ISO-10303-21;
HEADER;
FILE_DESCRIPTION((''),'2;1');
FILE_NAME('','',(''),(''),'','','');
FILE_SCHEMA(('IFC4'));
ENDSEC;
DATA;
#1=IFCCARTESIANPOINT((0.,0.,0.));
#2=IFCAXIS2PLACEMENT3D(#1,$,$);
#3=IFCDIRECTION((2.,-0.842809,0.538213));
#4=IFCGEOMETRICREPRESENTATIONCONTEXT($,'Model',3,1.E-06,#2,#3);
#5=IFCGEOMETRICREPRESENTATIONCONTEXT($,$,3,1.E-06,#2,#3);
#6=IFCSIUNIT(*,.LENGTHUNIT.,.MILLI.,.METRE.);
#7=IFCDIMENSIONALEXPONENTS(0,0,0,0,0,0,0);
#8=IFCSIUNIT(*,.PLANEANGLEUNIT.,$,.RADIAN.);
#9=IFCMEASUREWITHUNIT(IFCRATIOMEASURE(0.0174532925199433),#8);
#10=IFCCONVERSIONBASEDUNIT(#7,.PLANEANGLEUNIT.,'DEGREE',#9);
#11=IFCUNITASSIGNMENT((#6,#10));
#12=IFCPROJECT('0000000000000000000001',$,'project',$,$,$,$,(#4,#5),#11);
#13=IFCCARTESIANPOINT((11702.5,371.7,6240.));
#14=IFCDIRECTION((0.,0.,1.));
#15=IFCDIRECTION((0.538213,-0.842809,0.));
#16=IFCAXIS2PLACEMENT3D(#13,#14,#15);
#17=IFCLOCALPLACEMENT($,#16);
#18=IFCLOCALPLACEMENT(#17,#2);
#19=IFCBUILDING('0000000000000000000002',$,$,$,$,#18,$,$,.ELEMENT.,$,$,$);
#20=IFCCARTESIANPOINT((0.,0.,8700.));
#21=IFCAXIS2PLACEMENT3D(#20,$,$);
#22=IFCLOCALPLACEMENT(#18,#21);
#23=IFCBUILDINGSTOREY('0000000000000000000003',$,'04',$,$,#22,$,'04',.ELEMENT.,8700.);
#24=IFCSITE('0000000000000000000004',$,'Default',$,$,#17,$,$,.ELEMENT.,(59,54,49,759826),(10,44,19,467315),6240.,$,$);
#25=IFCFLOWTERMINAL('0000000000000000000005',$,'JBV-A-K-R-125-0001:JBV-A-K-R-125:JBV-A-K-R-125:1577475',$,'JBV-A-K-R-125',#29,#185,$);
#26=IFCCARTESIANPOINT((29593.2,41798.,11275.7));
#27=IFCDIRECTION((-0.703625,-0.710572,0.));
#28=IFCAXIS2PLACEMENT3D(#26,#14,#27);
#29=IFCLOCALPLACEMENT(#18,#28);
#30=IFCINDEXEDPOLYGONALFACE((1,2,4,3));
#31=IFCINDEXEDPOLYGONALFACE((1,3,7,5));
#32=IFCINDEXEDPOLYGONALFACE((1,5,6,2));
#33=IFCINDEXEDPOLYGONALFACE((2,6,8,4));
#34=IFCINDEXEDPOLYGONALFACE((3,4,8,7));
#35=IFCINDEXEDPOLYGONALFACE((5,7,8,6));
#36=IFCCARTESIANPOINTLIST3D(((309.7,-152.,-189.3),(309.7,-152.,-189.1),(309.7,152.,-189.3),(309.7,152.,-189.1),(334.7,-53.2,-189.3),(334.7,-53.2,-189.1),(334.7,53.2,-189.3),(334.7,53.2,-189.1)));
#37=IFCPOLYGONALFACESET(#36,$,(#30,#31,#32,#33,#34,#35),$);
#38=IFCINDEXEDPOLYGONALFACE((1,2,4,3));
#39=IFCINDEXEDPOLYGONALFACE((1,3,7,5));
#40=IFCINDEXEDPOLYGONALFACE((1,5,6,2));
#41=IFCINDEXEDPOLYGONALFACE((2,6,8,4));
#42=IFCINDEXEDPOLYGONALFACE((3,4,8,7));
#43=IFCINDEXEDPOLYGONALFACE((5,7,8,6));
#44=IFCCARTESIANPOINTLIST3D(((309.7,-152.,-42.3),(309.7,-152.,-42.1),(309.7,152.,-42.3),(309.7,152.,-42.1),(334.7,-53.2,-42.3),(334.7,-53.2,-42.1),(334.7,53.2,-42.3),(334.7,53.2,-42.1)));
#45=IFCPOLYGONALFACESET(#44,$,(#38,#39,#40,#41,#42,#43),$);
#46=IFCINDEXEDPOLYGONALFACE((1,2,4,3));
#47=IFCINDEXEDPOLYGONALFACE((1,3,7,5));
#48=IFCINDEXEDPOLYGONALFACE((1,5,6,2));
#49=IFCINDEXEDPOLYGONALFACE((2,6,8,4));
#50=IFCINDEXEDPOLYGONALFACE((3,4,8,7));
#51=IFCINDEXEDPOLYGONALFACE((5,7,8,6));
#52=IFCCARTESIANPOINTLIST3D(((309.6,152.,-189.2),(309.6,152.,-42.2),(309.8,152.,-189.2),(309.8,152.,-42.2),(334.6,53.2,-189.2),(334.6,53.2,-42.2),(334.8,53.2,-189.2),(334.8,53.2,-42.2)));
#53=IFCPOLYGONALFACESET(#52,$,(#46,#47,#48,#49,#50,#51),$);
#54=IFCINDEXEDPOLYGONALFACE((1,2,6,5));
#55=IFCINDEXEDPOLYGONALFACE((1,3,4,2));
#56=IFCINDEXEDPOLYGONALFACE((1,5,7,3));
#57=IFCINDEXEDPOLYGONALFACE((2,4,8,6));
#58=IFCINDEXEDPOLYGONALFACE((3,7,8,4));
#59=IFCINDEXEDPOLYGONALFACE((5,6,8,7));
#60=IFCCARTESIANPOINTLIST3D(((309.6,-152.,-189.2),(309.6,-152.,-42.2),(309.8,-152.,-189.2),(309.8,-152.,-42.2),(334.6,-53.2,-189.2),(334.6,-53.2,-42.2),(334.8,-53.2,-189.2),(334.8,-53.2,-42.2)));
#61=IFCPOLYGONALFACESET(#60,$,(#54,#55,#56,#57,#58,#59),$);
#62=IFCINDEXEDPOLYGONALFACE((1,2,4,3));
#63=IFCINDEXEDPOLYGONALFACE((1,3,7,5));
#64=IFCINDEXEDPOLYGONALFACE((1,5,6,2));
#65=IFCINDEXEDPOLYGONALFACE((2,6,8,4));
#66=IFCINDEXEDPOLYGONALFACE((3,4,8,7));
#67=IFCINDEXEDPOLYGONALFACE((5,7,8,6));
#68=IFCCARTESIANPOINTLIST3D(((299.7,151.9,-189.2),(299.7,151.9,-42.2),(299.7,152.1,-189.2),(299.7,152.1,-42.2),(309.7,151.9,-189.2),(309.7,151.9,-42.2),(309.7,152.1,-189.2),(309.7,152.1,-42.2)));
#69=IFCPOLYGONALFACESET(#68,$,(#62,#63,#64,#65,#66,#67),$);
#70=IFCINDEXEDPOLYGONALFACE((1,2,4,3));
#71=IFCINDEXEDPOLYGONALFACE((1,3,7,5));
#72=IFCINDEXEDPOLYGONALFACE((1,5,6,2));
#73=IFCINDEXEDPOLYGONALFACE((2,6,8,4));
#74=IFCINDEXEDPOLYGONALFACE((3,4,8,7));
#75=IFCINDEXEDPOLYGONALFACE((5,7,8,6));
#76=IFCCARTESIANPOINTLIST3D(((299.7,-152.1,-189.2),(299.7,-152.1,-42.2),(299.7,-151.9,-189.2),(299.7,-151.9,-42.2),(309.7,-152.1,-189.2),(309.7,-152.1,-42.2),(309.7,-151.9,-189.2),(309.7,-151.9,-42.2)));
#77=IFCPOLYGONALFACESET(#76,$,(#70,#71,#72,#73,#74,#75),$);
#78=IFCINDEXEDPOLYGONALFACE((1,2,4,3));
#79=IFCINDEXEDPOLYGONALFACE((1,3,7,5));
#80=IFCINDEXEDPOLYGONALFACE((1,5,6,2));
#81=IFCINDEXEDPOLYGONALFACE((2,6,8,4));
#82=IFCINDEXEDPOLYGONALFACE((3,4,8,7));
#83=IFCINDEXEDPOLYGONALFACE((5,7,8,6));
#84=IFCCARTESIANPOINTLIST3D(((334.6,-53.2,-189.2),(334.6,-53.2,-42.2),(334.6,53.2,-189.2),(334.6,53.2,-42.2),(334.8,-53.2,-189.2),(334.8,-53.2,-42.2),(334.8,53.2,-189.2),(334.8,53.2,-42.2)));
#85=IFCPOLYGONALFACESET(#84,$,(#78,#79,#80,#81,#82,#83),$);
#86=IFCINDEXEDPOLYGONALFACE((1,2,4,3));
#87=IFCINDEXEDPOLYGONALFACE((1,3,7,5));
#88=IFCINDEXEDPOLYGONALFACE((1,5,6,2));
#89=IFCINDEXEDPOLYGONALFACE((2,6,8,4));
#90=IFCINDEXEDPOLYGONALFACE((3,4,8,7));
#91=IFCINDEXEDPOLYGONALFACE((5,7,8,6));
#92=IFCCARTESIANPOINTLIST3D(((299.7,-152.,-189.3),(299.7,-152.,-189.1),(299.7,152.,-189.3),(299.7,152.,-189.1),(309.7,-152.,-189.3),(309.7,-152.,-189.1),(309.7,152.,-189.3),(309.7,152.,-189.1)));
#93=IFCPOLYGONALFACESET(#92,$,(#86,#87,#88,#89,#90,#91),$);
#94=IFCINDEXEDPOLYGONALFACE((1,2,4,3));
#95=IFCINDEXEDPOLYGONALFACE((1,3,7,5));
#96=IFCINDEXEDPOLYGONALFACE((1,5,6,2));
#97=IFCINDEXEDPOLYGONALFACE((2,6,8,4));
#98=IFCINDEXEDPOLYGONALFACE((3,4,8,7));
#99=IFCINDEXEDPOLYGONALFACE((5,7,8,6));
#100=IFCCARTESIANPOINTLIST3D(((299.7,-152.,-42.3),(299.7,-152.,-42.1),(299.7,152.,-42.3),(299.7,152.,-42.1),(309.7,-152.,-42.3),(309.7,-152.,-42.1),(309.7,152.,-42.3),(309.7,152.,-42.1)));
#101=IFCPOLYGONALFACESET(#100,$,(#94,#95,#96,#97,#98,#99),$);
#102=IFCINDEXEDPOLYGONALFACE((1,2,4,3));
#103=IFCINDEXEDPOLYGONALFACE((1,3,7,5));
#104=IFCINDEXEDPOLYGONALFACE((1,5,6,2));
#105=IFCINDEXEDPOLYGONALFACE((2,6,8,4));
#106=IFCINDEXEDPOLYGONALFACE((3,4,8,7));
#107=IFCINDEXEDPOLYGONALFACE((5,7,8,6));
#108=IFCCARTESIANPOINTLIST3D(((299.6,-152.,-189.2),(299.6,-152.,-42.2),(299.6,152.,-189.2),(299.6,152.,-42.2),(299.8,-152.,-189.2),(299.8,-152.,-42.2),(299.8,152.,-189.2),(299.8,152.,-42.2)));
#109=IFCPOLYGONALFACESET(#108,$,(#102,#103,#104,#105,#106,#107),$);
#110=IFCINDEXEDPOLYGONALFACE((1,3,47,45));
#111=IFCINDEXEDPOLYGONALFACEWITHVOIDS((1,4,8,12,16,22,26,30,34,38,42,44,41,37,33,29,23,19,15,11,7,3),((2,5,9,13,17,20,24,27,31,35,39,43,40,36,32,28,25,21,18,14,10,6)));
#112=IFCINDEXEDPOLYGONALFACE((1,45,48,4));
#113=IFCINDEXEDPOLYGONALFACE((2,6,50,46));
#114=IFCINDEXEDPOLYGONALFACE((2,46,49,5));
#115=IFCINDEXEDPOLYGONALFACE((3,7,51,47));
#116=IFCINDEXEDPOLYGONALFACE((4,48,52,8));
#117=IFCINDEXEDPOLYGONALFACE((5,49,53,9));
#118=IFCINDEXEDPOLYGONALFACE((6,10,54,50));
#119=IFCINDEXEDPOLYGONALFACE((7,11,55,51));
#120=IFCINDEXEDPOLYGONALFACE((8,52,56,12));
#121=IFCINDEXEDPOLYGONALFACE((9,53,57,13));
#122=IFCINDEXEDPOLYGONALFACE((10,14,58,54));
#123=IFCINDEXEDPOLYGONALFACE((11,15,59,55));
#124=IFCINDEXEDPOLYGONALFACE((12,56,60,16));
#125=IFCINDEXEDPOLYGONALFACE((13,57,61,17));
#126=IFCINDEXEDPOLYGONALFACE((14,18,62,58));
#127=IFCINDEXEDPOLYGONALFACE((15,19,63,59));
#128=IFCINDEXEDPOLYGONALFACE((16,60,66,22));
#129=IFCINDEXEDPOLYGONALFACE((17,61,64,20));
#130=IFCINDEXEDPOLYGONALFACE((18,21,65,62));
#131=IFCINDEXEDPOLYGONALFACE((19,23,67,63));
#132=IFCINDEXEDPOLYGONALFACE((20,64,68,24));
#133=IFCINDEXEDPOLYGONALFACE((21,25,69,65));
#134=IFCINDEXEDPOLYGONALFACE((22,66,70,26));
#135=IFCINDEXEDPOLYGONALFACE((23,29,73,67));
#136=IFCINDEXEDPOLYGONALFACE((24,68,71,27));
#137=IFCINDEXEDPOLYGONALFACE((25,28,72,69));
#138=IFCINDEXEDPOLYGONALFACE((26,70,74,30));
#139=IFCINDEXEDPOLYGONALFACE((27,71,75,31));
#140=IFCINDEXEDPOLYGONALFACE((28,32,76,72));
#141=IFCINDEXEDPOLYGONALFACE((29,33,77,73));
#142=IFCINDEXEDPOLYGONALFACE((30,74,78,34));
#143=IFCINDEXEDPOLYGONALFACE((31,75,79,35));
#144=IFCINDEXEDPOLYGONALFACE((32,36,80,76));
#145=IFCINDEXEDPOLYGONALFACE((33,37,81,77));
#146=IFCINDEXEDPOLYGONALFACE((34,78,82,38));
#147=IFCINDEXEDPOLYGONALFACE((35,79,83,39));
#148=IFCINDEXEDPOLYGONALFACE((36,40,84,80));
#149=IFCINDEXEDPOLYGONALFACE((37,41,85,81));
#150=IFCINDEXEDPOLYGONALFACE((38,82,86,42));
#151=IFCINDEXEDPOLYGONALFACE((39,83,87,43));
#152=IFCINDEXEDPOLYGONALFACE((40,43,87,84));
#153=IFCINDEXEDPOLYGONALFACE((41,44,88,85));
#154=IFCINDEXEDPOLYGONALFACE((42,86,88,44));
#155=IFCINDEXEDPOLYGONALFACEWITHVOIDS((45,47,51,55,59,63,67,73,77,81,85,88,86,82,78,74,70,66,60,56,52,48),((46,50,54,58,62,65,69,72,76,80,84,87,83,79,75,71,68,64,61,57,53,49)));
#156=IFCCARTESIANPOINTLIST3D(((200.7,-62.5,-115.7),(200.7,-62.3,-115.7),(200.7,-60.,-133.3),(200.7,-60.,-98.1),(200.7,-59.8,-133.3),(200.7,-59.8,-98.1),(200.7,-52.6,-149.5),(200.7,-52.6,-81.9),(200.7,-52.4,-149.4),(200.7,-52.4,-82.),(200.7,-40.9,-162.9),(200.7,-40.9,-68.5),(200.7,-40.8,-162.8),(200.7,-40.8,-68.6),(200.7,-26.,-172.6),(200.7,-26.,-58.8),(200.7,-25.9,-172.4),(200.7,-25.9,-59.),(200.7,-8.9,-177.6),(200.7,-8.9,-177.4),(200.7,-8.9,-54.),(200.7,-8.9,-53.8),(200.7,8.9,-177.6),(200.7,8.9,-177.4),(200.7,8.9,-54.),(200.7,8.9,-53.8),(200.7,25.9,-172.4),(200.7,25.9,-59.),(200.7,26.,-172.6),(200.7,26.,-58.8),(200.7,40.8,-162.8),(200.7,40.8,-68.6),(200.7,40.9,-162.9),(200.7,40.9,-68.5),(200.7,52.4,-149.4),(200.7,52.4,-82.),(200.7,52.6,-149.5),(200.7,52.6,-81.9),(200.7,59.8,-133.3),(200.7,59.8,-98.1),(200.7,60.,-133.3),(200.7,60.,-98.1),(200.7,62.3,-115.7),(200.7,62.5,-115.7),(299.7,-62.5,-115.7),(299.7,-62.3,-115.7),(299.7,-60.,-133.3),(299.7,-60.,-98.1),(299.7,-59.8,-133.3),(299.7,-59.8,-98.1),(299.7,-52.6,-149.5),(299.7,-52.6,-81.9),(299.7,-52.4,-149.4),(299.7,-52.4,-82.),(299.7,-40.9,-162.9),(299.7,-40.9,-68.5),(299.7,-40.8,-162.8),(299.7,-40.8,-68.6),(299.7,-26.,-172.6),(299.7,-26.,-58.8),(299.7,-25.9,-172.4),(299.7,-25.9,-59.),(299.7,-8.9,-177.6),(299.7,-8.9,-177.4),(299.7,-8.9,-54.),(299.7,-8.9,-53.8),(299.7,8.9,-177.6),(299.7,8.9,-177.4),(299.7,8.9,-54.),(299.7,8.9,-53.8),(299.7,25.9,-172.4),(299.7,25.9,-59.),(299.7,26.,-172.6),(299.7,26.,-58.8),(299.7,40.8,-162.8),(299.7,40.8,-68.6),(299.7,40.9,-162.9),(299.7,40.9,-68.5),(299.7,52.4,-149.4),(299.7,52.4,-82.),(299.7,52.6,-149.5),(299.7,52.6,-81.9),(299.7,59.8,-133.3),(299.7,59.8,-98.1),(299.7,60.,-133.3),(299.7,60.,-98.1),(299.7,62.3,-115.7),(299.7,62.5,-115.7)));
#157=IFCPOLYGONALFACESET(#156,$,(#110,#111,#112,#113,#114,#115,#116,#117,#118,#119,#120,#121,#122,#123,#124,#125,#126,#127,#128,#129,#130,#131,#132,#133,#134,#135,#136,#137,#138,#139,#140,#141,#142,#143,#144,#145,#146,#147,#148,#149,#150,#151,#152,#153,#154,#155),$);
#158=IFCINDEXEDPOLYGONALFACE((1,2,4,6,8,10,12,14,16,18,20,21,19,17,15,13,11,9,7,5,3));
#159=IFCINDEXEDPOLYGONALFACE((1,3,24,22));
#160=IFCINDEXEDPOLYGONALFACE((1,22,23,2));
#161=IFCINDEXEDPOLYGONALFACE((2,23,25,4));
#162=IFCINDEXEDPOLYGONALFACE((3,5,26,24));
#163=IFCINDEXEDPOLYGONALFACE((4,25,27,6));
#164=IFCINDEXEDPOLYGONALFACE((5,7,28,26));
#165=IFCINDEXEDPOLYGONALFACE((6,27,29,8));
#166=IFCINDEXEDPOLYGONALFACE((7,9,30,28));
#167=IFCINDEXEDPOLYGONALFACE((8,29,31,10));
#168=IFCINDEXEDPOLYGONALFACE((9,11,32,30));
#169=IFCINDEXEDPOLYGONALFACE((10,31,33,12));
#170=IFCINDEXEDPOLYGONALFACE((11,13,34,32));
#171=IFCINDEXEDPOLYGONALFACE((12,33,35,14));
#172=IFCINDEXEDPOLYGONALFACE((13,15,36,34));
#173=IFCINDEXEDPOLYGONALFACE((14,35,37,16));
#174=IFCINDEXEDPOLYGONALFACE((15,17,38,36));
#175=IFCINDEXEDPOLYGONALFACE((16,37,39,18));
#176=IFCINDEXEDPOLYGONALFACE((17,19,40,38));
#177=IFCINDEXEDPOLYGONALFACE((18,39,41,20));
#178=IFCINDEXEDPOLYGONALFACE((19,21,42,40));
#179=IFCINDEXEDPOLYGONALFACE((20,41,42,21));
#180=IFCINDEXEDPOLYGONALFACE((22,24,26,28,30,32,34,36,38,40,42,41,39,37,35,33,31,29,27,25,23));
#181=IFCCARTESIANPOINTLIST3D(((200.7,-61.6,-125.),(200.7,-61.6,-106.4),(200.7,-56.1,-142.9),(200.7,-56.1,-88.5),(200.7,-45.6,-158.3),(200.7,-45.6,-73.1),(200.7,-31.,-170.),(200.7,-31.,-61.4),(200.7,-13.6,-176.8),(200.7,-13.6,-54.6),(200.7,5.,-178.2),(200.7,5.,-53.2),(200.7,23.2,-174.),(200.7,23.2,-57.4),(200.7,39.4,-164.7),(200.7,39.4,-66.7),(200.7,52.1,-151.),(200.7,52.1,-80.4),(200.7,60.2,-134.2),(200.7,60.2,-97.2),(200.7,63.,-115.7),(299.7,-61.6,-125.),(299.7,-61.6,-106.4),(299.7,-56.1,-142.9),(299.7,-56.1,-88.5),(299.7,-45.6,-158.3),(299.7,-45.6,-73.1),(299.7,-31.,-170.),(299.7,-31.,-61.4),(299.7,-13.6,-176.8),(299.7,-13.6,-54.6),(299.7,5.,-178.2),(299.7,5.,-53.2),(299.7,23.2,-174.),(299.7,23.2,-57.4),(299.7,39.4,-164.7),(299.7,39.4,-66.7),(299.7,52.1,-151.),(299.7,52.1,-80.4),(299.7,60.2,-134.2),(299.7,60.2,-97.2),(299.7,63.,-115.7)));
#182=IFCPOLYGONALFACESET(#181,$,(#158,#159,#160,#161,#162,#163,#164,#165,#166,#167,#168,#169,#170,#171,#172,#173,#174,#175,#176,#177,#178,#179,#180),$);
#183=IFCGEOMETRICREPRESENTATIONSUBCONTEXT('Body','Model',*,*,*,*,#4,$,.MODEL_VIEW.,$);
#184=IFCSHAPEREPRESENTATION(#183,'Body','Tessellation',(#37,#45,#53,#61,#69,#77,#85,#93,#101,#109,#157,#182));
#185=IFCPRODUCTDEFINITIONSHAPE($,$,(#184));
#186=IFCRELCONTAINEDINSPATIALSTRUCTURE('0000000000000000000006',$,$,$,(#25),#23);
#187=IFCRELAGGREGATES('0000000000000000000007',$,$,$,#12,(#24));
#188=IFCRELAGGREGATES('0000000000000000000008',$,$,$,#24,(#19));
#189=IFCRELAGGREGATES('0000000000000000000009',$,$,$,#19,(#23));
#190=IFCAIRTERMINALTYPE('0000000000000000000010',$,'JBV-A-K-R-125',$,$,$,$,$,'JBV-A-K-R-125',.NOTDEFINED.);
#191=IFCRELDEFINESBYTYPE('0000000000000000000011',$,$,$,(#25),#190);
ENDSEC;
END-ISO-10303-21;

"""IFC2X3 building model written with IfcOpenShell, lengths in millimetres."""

from ifc_helpers import new_model, entity, si_unit, converted_unit, direction, frame, frame_2d, origin, origin_2d_with_axis, place, context, subcontext, project, spatial, polyline, circle_curve, parameter, trimmed, segment, composite_curve, rectangle, circle, outline, extrude, source, transform, mapped, type_object, type_shapes, element, save


model = new_model("IFC2X3")

# Units and contexts
model_context = context("Model", 3, precision=1e-06, world=origin(), true_north=direction((2.0, -0.842809, 0.538213)))
context_of_model = context(None, 3, precision=1e-06, world=origin(), true_north=direction((2.0, -0.842809, 0.538213)))
body_context = subcontext(model_context, "Body", "Model", "MODEL_VIEW")
ifc_project = project(units=[si_unit("LENGTHUNIT", "METRE", prefix="MILLI"), converted_unit("PLANEANGLEUNIT", "DEGREE", entity("IfcRatioMeasure", 0.0174532925199433), si_unit("PLANEANGLEUNIT", "RADIAN"), dimensions=[0, 0, 0, 0, 0, 0, 0])], contexts=[model_context, context_of_model])

# Site, building, storey
site_placement = place(None, frame((11702.5, 371.7, 6240.0), z_axis=(0.0, 0.0, 1.0), x_axis=(0.538213, -0.842809, 0.0)))
site = spatial("IfcSite", under=ifc_project, at=site_placement, Name="Default", CompositionType="ELEMENT", RefLatitude=(59, 54, 49, 759826), RefLongitude=(10, 44, 19, 467315), RefElevation=6240.0)
building_placement = place(site_placement, origin())
building = spatial("IfcBuilding", under=site, at=building_placement, CompositionType="ELEMENT")
storey_placement = place(building_placement, frame((0.0, 0.0, 8700.0)))
storey = spatial("IfcBuildingStorey", under=building, at=storey_placement, Name="04", LongName="04", CompositionType="ELEMENT", Elevation=8700.0)

# Flow terminal
air_terminal_type_1 = type_object("IfcAirTerminalType", Name="JBV-A-K-R-125", ElementType="JBV-A-K-R-125", PredefinedType="NOTDEFINED")
shared_shape_1 = source(origin(), body_context, "Body", "SweptSolid", [
    extrude(outline(polyline([(-152.0, -12.5), (152.0, -12.5), (53.2, 12.5), (-53.2, 12.5), (-152.0, -12.5)])), frame((322.2, 0.0, -189.3), z_axis=(0.0, 0.0, 1.0), x_axis=(0.0, -1.0, 0.0)), (0.0, 0.0, 1.0), 0.2),
    extrude(outline(polyline([(-152.0, -12.5), (152.0, -12.5), (53.2, 12.5), (-53.2, 12.5), (-152.0, -12.5)])), frame((322.2, 0.0, -42.3), z_axis=(0.0, 0.0, 1.0), x_axis=(0.0, -1.0, 0.0)), (0.0, 0.0, 1.0), 0.2),
    extrude(rectangle(XDim=0.2, YDim=101.9, at=frame_2d((0.0, 0.0), x_axis=(1.0, 0.0))), frame((322.2, 102.6, -189.2), z_axis=(0.0, 0.0, 1.0), x_axis=(0.969446, 0.245305, 0.0)), (0.0, 0.0, 1.0), 147.0),
    extrude(rectangle(XDim=0.2, YDim=101.9, at=frame_2d((0.0, 0.0), x_axis=(1.0, 0.0))), frame((322.2, -102.6, -189.2), z_axis=(0.0, 0.0, 1.0), x_axis=(-0.969446, 0.245305, 0.0)), (0.0, 0.0, 1.0), 147.0),
    extrude(rectangle(XDim=0.2, YDim=10.0, at=frame_2d((0.0, 0.0), x_axis=(1.0, 0.0))), frame((304.7, 152.0, -189.2), z_axis=(0.0, 0.0, 1.0), x_axis=(0.0, 1.0, 0.0)), (0.0, 0.0, 1.0), 147.0),
    extrude(rectangle(XDim=0.2, YDim=10.0, at=frame_2d((0.0, 0.0), x_axis=(1.0, 0.0))), frame((304.7, -152.0, -189.2), z_axis=(0.0, 0.0, 1.0), x_axis=(0.0, 1.0, 0.0)), (0.0, 0.0, 1.0), 147.0),
    extrude(rectangle(XDim=0.2, YDim=106.4, at=frame_2d((0.0, 0.0), x_axis=(1.0, 0.0))), frame((334.7, 0.0, -189.2)), (0.0, 0.0, 1.0), 147.0),
    extrude(rectangle(XDim=304.0, YDim=10.0, at=frame_2d((0.0, 0.0), x_axis=(1.0, 0.0))), frame((304.7, 0.0, -189.3), z_axis=(0.0, 0.0, 1.0), x_axis=(0.0, -1.0, 0.0)), (0.0, 0.0, 1.0), 0.2),
    extrude(rectangle(XDim=304.0, YDim=10.0, at=frame_2d((0.0, 0.0), x_axis=(1.0, 0.0))), frame((304.7, 0.0, -42.3), z_axis=(0.0, 0.0, 1.0), x_axis=(0.0, -1.0, 0.0)), (0.0, 0.0, 1.0), 0.2),
    extrude(rectangle(XDim=0.2, YDim=304.0, at=frame_2d((0.0, 0.0), x_axis=(1.0, 0.0))), frame((299.7, 0.0, -189.2)), (0.0, 0.0, 1.0), 147.0),
    extrude(outline(composite_curve([segment(trimmed(circle_curve(origin_2d_with_axis(), 62.5), [parameter(0.0)], [parameter(180.0)], True, "PARAMETER"), True, "CONTINUOUS"), segment(trimmed(circle_curve(origin_2d_with_axis(), 62.5), [parameter(180.0)], [parameter(360.0)], True, "PARAMETER"), True, "CONTINUOUS")], self_intersect=False), holes=[composite_curve([segment(trimmed(circle_curve(origin_2d_with_axis(), 62.3), [parameter(180.0)], [parameter(360.0)], True, "PARAMETER"), False, "CONTINUOUS"), segment(trimmed(circle_curve(origin_2d_with_axis(), 62.3), [parameter(0.0)], [parameter(180.0)], True, "PARAMETER"), False, "CONTINUOUS")], self_intersect=False)]), frame((200.7, 0.0, -115.7), z_axis=(1.0, 0.0, 0.0), x_axis=(0.0, 1.0, 0.0)), (0.0, 0.0, 1.0), 99.0),
    extrude(circle(Radius=62.6, at=frame_2d((0.0, 0.0), x_axis=(1.0, 0.0))), frame((200.7, 0.3, -115.7), z_axis=(1.0, 0.0, 0.0), x_axis=(0.0, 1.0, 0.0)), (0.0, 0.0, 1.0), 99.0),
])
type_shapes(air_terminal_type_1, [shared_shape_1])
flow_terminal_1_placement = place(building_placement, frame((29593.2, 41798.0, 11275.7), z_axis=(0.0, 0.0, 1.0), x_axis=(-0.703625, -0.710572, 0.0)))
element("IfcFlowTerminal", 1, at=flow_terminal_1_placement, inside=storey, type_object=air_terminal_type_1, Name="JBV-A-K-R-125-0001:JBV-A-K-R-125:JBV-A-K-R-125:1577475", ObjectType="JBV-A-K-R-125", context=body_context, shape_type="MappedRepresentation", body=[
    mapped(shared_shape_1, transform((0.0, 0.0, 0.0), scale=1.0)),
])

save(model, "model.ifc")
